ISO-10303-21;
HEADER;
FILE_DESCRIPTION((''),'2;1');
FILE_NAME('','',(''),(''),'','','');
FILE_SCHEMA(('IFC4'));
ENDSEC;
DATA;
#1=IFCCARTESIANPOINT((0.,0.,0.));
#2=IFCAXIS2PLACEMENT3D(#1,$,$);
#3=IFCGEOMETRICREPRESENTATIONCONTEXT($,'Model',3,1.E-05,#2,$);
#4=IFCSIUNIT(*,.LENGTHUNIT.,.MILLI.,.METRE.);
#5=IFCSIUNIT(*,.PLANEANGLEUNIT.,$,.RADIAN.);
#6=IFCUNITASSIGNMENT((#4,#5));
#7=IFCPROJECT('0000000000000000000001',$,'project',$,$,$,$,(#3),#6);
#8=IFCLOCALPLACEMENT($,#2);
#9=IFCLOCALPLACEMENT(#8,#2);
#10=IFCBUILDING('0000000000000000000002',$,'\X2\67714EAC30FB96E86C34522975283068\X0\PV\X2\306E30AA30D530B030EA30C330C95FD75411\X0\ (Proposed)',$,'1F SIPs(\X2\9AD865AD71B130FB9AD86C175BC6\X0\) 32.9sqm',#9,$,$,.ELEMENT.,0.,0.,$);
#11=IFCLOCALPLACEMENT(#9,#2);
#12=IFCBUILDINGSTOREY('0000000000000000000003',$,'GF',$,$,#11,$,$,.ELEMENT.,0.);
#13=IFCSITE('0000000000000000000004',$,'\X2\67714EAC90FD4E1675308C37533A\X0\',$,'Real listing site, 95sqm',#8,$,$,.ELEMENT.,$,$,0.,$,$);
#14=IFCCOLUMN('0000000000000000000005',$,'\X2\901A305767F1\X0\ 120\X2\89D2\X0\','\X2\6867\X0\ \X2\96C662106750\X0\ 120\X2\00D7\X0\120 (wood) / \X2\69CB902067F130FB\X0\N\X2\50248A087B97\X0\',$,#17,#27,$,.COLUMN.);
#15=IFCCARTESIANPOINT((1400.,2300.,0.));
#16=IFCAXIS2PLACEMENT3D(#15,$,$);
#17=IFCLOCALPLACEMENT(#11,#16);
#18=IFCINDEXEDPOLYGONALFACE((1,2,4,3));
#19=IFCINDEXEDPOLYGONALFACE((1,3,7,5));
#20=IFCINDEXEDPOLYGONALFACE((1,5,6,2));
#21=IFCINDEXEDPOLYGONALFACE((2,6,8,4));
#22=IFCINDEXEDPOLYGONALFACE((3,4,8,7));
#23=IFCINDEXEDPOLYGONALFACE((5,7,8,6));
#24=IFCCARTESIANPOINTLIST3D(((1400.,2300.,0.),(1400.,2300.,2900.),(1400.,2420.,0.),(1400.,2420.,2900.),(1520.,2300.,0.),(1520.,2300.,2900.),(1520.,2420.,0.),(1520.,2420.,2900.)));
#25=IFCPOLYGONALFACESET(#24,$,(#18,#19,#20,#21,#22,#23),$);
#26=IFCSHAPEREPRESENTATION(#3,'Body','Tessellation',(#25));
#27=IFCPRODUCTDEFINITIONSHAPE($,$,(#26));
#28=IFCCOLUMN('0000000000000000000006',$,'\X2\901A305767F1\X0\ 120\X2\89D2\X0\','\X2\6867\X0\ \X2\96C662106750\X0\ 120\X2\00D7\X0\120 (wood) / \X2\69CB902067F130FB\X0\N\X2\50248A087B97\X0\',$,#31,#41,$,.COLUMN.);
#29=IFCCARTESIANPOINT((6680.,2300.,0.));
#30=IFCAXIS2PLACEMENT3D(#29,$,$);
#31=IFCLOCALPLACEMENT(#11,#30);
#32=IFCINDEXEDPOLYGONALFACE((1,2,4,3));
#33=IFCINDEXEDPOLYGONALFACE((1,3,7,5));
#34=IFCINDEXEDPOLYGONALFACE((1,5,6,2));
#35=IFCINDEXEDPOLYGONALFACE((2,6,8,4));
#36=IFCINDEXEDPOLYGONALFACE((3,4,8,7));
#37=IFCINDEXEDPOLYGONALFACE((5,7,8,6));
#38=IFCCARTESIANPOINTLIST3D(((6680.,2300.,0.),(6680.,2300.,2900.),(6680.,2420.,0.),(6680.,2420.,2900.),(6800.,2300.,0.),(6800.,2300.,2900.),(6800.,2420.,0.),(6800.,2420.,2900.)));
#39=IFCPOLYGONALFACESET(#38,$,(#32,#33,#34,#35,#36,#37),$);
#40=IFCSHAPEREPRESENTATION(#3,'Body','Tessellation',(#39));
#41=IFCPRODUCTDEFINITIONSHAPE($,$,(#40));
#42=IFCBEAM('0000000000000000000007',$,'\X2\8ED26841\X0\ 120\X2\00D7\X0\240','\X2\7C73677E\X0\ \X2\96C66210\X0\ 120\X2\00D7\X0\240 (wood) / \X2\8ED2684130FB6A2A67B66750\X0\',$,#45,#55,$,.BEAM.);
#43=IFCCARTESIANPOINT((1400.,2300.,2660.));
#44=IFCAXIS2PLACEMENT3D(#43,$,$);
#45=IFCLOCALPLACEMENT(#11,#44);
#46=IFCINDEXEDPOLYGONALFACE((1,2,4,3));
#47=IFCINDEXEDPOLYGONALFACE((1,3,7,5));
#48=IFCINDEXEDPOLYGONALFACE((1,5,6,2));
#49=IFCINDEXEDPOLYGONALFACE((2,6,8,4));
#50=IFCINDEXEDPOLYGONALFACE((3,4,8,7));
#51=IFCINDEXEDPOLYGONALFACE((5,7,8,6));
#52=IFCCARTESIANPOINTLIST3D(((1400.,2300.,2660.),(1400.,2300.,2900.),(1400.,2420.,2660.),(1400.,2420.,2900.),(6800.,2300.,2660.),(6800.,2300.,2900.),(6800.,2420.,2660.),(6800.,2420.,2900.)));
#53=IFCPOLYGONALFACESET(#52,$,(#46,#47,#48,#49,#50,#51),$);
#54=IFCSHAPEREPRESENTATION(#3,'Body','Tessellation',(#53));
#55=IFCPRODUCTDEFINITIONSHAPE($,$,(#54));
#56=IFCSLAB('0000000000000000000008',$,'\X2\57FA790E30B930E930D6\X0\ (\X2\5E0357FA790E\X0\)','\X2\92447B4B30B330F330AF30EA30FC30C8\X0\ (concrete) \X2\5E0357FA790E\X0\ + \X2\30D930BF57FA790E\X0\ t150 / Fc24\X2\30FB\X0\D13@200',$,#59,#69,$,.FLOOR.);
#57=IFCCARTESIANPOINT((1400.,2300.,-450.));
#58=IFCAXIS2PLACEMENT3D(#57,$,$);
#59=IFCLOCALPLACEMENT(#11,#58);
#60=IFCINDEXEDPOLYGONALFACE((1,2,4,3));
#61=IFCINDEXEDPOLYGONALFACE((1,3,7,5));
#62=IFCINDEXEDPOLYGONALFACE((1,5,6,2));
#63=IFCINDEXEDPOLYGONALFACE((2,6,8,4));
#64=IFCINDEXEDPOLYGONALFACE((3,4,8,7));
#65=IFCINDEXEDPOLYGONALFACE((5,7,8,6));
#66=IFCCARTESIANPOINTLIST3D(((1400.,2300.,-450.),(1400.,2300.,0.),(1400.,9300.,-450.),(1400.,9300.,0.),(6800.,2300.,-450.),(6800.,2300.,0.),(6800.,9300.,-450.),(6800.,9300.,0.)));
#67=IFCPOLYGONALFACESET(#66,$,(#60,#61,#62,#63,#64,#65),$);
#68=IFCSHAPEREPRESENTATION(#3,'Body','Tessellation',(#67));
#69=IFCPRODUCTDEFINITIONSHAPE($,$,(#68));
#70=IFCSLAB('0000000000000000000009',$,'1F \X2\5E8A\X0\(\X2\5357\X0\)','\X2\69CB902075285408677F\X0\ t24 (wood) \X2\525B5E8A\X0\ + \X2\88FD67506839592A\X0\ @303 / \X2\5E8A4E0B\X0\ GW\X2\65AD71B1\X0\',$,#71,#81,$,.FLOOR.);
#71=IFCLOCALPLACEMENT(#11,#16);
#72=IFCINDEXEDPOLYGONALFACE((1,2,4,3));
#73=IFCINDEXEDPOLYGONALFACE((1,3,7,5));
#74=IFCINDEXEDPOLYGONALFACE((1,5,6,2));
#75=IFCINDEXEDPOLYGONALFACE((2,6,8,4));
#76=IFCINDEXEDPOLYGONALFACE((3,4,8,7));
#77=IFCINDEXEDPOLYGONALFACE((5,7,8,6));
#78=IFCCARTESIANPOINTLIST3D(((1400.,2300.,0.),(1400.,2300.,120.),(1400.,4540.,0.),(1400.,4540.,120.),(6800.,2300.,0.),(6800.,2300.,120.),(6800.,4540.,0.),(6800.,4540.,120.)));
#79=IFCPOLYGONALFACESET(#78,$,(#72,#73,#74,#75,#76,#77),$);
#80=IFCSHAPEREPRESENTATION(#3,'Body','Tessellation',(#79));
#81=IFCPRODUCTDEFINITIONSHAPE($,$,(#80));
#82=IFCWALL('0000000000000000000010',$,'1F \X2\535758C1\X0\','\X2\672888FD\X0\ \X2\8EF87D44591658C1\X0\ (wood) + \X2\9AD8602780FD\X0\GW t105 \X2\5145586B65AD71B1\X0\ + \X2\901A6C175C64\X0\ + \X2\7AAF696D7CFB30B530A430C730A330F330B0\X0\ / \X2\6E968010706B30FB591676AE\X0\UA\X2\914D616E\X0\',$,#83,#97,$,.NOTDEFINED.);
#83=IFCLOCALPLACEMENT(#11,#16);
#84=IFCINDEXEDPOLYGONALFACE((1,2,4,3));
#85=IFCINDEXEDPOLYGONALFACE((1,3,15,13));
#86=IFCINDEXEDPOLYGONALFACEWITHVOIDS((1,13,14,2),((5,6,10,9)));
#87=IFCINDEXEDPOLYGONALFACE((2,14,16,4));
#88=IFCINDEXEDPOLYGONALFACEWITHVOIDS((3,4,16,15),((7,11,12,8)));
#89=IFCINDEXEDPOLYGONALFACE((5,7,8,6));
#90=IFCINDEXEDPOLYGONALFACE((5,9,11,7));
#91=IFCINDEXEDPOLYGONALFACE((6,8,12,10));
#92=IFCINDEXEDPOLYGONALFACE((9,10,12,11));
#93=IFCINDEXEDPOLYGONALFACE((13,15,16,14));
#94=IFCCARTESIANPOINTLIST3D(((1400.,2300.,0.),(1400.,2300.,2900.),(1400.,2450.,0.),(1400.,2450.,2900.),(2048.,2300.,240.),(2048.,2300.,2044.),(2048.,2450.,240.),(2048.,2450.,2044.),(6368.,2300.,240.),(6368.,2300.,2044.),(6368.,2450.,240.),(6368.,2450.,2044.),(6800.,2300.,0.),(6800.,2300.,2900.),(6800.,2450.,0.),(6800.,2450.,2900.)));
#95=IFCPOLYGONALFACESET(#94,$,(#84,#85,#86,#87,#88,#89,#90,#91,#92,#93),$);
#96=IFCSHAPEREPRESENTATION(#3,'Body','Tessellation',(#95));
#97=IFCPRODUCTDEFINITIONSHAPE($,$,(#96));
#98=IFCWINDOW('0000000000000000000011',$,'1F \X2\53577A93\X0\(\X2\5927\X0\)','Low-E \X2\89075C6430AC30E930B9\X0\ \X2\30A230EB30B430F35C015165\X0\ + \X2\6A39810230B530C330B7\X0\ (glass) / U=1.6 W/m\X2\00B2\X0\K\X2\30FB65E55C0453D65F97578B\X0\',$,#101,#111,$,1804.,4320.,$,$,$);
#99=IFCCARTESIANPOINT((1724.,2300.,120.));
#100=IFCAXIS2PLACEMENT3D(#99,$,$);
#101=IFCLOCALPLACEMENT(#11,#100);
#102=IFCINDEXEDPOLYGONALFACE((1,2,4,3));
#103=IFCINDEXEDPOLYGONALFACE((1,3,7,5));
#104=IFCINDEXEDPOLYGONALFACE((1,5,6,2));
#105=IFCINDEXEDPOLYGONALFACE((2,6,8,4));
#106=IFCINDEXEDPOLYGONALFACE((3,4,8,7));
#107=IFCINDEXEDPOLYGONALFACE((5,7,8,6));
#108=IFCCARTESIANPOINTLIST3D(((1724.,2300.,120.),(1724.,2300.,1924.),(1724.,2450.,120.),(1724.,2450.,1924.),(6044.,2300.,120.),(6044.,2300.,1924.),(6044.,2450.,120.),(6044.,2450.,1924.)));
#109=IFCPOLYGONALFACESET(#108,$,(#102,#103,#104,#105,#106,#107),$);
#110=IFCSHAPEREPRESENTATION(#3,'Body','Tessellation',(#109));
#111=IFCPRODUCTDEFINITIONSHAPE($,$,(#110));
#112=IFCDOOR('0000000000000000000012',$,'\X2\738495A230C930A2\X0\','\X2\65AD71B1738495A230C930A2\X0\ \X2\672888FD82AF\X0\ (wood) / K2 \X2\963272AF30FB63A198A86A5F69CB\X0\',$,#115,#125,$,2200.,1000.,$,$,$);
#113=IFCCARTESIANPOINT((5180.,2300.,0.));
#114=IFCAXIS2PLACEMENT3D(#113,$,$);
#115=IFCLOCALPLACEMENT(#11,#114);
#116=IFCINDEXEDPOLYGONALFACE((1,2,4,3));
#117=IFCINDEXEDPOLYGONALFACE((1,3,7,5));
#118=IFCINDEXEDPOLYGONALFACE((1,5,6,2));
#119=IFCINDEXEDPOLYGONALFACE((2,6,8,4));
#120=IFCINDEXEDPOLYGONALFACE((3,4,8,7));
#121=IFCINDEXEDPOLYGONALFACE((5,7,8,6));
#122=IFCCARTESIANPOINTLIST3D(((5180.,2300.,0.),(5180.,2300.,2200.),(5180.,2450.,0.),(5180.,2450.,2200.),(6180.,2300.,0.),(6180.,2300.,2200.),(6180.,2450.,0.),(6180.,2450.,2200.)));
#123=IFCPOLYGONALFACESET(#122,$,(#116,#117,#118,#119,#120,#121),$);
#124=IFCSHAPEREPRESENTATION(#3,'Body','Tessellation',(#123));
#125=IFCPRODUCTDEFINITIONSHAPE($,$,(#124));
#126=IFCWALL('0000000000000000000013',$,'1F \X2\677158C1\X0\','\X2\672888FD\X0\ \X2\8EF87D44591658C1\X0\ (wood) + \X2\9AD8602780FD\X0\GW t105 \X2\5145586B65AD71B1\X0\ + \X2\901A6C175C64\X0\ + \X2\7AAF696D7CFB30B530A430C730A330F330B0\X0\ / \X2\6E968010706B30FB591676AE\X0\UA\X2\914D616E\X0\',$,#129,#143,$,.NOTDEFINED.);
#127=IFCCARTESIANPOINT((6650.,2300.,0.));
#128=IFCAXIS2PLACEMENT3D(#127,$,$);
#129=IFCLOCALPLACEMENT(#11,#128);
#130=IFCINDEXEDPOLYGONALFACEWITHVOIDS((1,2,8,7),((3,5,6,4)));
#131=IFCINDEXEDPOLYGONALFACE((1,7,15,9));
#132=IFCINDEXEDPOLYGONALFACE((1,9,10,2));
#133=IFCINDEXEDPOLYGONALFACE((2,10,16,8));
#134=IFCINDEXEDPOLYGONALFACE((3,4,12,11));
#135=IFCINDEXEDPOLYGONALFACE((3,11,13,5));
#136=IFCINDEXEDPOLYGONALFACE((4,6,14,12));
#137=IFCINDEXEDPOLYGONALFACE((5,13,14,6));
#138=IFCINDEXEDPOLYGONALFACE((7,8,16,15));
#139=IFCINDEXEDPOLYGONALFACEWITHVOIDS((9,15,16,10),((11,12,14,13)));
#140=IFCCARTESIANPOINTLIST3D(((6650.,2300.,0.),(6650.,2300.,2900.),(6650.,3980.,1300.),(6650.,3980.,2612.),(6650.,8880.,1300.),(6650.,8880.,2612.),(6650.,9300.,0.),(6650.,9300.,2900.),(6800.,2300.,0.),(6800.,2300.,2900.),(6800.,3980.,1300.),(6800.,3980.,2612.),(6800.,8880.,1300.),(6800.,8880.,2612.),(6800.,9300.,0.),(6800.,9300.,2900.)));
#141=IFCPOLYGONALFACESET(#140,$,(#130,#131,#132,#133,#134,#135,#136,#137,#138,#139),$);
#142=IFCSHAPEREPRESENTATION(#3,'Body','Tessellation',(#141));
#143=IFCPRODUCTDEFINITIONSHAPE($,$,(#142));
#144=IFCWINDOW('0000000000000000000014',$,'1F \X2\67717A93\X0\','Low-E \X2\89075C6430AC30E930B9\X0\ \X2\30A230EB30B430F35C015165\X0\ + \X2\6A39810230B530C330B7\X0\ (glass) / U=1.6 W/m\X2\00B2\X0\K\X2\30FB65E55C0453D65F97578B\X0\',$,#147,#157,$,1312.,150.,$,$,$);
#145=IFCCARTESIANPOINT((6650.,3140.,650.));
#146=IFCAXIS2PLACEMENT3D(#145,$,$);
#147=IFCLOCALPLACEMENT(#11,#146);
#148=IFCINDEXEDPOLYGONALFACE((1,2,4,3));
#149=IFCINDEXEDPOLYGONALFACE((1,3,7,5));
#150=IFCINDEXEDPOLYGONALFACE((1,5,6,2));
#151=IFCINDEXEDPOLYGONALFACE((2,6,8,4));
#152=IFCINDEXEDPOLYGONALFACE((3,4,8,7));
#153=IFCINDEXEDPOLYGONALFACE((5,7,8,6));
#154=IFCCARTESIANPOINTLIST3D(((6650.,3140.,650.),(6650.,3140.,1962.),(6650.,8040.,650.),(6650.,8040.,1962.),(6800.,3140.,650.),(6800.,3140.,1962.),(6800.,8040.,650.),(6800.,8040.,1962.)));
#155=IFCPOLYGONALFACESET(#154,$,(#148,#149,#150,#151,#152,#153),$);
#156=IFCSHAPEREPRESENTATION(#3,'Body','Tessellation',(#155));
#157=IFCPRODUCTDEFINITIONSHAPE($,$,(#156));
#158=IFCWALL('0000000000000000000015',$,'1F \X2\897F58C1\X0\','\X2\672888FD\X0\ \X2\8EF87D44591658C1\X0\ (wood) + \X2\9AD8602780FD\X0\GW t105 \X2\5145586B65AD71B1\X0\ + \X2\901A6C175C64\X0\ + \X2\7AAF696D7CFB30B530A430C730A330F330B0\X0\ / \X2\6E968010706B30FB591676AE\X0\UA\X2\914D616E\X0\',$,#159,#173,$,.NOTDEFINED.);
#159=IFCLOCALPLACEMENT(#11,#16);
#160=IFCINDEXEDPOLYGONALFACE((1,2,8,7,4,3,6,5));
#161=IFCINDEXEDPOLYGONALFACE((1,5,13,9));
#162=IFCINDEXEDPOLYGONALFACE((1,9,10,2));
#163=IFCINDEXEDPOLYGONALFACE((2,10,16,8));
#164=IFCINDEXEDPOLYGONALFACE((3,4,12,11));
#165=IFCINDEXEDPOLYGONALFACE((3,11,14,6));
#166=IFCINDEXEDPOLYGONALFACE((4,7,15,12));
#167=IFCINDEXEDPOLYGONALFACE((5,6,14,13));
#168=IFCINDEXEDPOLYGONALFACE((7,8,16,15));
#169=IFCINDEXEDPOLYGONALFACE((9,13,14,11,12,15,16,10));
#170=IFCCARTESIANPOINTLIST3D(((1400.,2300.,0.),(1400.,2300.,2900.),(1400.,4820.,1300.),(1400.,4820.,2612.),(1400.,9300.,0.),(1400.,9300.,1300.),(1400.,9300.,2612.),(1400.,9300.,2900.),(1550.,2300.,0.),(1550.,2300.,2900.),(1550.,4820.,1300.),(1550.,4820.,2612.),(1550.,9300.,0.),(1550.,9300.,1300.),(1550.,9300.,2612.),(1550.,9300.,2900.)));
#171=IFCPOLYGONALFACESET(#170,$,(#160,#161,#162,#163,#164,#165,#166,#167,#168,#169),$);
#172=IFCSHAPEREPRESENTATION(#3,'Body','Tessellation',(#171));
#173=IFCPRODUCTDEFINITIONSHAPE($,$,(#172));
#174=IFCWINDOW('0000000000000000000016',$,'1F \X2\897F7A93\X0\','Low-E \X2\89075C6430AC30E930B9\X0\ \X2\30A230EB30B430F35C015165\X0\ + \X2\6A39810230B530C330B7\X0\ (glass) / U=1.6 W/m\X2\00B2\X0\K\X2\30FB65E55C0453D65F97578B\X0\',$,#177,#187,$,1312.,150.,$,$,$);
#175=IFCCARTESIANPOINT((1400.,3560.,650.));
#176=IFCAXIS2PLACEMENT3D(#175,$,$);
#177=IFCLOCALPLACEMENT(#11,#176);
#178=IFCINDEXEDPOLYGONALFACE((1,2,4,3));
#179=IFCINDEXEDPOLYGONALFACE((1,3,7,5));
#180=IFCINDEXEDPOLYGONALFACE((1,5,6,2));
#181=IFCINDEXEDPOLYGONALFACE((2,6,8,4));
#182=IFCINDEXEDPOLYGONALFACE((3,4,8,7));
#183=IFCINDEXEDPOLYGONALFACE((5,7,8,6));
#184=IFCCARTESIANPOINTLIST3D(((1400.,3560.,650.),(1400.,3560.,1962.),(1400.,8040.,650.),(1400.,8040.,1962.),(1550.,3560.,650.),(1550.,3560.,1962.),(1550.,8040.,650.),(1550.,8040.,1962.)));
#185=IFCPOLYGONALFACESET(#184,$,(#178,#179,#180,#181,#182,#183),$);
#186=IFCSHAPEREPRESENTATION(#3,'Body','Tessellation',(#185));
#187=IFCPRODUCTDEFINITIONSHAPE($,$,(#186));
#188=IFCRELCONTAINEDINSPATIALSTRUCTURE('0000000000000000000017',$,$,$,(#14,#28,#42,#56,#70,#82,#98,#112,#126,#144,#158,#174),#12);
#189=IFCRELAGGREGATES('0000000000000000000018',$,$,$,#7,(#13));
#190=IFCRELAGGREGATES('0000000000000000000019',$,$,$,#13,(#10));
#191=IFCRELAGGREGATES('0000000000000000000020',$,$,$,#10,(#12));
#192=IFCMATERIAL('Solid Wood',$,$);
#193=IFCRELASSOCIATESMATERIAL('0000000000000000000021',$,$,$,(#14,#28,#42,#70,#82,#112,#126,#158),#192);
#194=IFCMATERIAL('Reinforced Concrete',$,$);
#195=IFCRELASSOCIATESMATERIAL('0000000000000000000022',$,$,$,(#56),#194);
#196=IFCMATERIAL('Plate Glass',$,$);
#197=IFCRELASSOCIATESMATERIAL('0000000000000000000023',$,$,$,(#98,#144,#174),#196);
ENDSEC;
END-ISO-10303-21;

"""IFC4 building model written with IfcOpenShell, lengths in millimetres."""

from ifc_helpers import new_model, si_unit, frame, frame_2d, origin, place, context, project, spatial, rectangle, extrude, material, element, fill, save


model = new_model("IFC4")

# Units and contexts
model_context = context("Model", 3, precision=1e-05, world=origin())
ifc_project = project(units=[si_unit("LENGTHUNIT", "METRE", prefix="MILLI"), si_unit("PLANEANGLEUNIT", "RADIAN")], contexts=[model_context])

# Site, building, storey
site_placement = place(None, origin())
site = spatial("IfcSite", under=ifc_project, at=site_placement, Name="東京都世田谷区", ObjectType="Real listing site, 95sqm", CompositionType="ELEMENT", RefElevation=0.0)
building_placement = place(site_placement, origin())
building = spatial("IfcBuilding", under=site, at=building_placement, Name="東京・雨水利用とPVのオフグリッド志向 (Proposed)", ObjectType="1F SIPs(高断熱・高気密) 32.9sqm", CompositionType="ELEMENT", ElevationOfRefHeight=0.0, ElevationOfTerrain=0.0)
storey_placement = place(building_placement, origin())
storey = spatial("IfcBuildingStorey", under=building, at=storey_placement, Name="GF", CompositionType="ELEMENT", Elevation=0.0)

# Columns
ifc_material_1 = material(Name="Solid Wood")
column_1_placement = place(storey_placement, frame((1400.0, 2300.0, 0.0)))
element("IfcColumn", 1, at=column_1_placement, inside=storey, material=ifc_material_1, Name="通し柱 120角", Description="桧 集成材 120×120 (wood) / 構造柱・N値計算", PredefinedType="COLUMN", context=model_context, shape_type="SweptSolid", body=[
    extrude(rectangle(XDim=120.0, YDim=120.0, at=frame_2d((60.0, 60.0))), frame((1400.0, 2300.0, 0.0)), (0.0, 0.0, 1.0), 2900.0),
])
column_2_placement = place(storey_placement, frame((6680.0, 2300.0, 0.0)))
element("IfcColumn", 2, at=column_2_placement, inside=storey, material=ifc_material_1, Name="通し柱 120角", Description="桧 集成材 120×120 (wood) / 構造柱・N値計算", PredefinedType="COLUMN", context=model_context, shape_type="SweptSolid", body=[
    extrude(rectangle(XDim=120.0, YDim=120.0, at=frame_2d((60.0, 60.0))), frame((6680.0, 2300.0, 0.0)), (0.0, 0.0, 1.0), 2900.0),
])

# Beam
beam_1_placement = place(storey_placement, frame((1400.0, 2300.0, 2660.0)))
element("IfcBeam", 3, at=beam_1_placement, inside=storey, material=ifc_material_1, Name="軒桁 120×240", Description="米松 集成 120×240 (wood) / 軒桁・横架材", PredefinedType="BEAM", context=model_context, shape_type="SweptSolid", body=[
    extrude(rectangle(XDim=5400.0, YDim=120.0, at=frame_2d((2700.0, 60.0))), frame((1400.0, 2300.0, 2660.0)), (0.0, 0.0, 1.0), 240.0),
])

# Slabs
ifc_material_2 = material(Name="Reinforced Concrete")
slab_1_placement = place(storey_placement, frame((1400.0, 2300.0, -450.0)))
element("IfcSlab", 4, at=slab_1_placement, inside=storey, material=ifc_material_2, Name="基礎スラブ (布基礎)", Description="鉄筋コンクリート (concrete) 布基礎 + ベタ基礎 t150 / Fc24・D13@200", PredefinedType="FLOOR", context=model_context, shape_type="SweptSolid", body=[
    extrude(rectangle(XDim=5400.0, YDim=7000.0, at=frame_2d((2700.0, 3500.0))), frame((1400.0, 2300.0, -450.0)), (0.0, 0.0, 1.0), 450.0),
])
slab_2_placement = place(storey_placement, frame((1400.0, 2300.0, 0.0)))
element("IfcSlab", 5, at=slab_2_placement, inside=storey, material=ifc_material_1, Name="1F 床(南)", Description="構造用合板 t24 (wood) 剛床 + 製材根太 @303 / 床下 GW断熱", PredefinedType="FLOOR", context=model_context, shape_type="SweptSolid", body=[
    extrude(rectangle(XDim=5400.0, YDim=2240.0, at=frame_2d((2700.0, 1120.0))), frame((1400.0, 2300.0, 0.0)), (0.0, 0.0, 1.0), 120.0),
])

# Wall, openings, window, door
wall_1_placement = place(storey_placement, frame((1400.0, 2300.0, 0.0)))
wall_1 = element("IfcWall", 6, at=wall_1_placement, inside=storey, material=ifc_material_1, Name="1F 南壁", Description="木製 軸組外壁 (wood) + 高性能GW t105 充填断熱 + 通気層 + 窯業系サイディング / 準耐火・外皮UA配慮", PredefinedType="NOTDEFINED", context=model_context, shape_type="SweptSolid", body=[
    extrude(rectangle(XDim=5400.0, YDim=150.0, at=frame_2d((2700.0, 75.0))), frame((1400.0, 2300.0, 0.0)), (0.0, 0.0, 1.0), 2900.0),
])
opening_1_placement = place(storey_placement, frame((1724.0, 2300.0, 120.0)))
opening_1 = element("IfcOpeningElement", 7, at=opening_1_placement, cuts=wall_1, PredefinedType="NOTDEFINED", context=model_context, shape_type="SweptSolid", body=[
    extrude(rectangle(XDim=4320.0, YDim=150.0, at=frame_2d((2160.0, 75.0))), frame((1724.0, 2300.0, 120.0)), (0.0, 0.0, 1.0), 1804.0),
])
opening_2_placement = place(storey_placement, frame((5180.0, 2300.0, 0.0)))
opening_2 = element("IfcOpeningElement", 8, at=opening_2_placement, cuts=wall_1, PredefinedType="NOTDEFINED", context=model_context, shape_type="SweptSolid", body=[
    extrude(rectangle(XDim=1000.0, YDim=150.0, at=frame_2d((500.0, 75.0))), frame((5180.0, 2300.0, 0.0)), (0.0, 0.0, 1.0), 2200.0),
])
ifc_material_3 = material(Name="Plate Glass")
window_1_placement = place(storey_placement, frame((1724.0, 2300.0, 120.0)))
window_1 = element("IfcWindow", 9, at=window_1_placement, inside=storey, material=ifc_material_3, Name="1F 南窓(大)", Description="Low-E 複層ガラス アルゴン封入 + 樹脂サッシ (glass) / U=1.6 W/m²K・日射取得型", OverallHeight=1804.0, OverallWidth=4320.0, context=model_context, shape_type="SweptSolid", body=[
    extrude(rectangle(XDim=4320.0, YDim=150.0, at=frame_2d((2160.0, 75.0))), frame((1724.0, 2300.0, 120.0)), (0.0, 0.0, 1.0), 1804.0),
])
fill(opening_1, window_1)
door_placement = place(storey_placement, frame((5180.0, 2300.0, 0.0)))
door = element("IfcDoor", 10, at=door_placement, inside=storey, material=ifc_material_1, Name="玄関ドア", Description="断熱玄関ドア 木製芯 (wood) / K2 防犯・採風機構", OverallHeight=2200.0, OverallWidth=1000.0, context=model_context, shape_type="SweptSolid", body=[
    extrude(rectangle(XDim=1000.0, YDim=150.0, at=frame_2d((500.0, 75.0))), frame((5180.0, 2300.0, 0.0)), (0.0, 0.0, 1.0), 2200.0),
])
fill(opening_2, door)

# Walls, openings, windows
wall_2_placement = place(storey_placement, frame((6650.0, 2300.0, 0.0)))
wall_2 = element("IfcWall", 11, at=wall_2_placement, inside=storey, material=ifc_material_1, Name="1F 東壁", Description="木製 軸組外壁 (wood) + 高性能GW t105 充填断熱 + 通気層 + 窯業系サイディング / 準耐火・外皮UA配慮", PredefinedType="NOTDEFINED", context=model_context, shape_type="SweptSolid", body=[
    extrude(rectangle(XDim=150.0, YDim=7000.0, at=frame_2d((75.0, 3500.0))), frame((6650.0, 2300.0, 0.0)), (0.0, 0.0, 1.0), 2900.0),
])
opening_3_placement = place(storey_placement, frame((6650.0, 3140.0, 650.0)))
opening_3 = element("IfcOpeningElement", 12, at=opening_3_placement, cuts=wall_2, PredefinedType="NOTDEFINED", context=model_context, shape_type="SweptSolid", body=[
    extrude(rectangle(XDim=150.0, YDim=4900.0, at=frame_2d((75.0, 2450.0))), frame((6650.0, 3140.0, 650.0)), (0.0, 0.0, 1.0), 1312.0),
])
window_2_placement = place(storey_placement, frame((6650.0, 3140.0, 650.0)))
window_2 = element("IfcWindow", 13, at=window_2_placement, inside=storey, material=ifc_material_3, Name="1F 東窓", Description="Low-E 複層ガラス アルゴン封入 + 樹脂サッシ (glass) / U=1.6 W/m²K・日射取得型", OverallHeight=1312.0, OverallWidth=150.0, context=model_context, shape_type="SweptSolid", body=[
    extrude(rectangle(XDim=150.0, YDim=4900.0, at=frame_2d((75.0, 2450.0))), frame((6650.0, 3140.0, 650.0)), (0.0, 0.0, 1.0), 1312.0),
])
fill(opening_3, window_2)
wall_3_placement = place(storey_placement, frame((1400.0, 2300.0, 0.0)))
wall_3 = element("IfcWall", 14, at=wall_3_placement, inside=storey, material=ifc_material_1, Name="1F 西壁", Description="木製 軸組外壁 (wood) + 高性能GW t105 充填断熱 + 通気層 + 窯業系サイディング / 準耐火・外皮UA配慮", PredefinedType="NOTDEFINED", context=model_context, shape_type="SweptSolid", body=[
    extrude(rectangle(XDim=150.0, YDim=7000.0, at=frame_2d((75.0, 3500.0))), frame((1400.0, 2300.0, 0.0)), (0.0, 0.0, 1.0), 2900.0),
])
opening_4_placement = place(storey_placement, frame((1400.0, 3560.0, 650.0)))
opening_4 = element("IfcOpeningElement", 15, at=opening_4_placement, cuts=wall_3, PredefinedType="NOTDEFINED", context=model_context, shape_type="SweptSolid", body=[
    extrude(rectangle(XDim=150.0, YDim=4480.0, at=frame_2d((75.0, 2240.0))), frame((1400.0, 3560.0, 650.0)), (0.0, 0.0, 1.0), 1312.0),
])
window_3_placement = place(storey_placement, frame((1400.0, 3560.0, 650.0)))
window_3 = element("IfcWindow", 16, at=window_3_placement, inside=storey, material=ifc_material_3, Name="1F 西窓", Description="Low-E 複層ガラス アルゴン封入 + 樹脂サッシ (glass) / U=1.6 W/m²K・日射取得型", OverallHeight=1312.0, OverallWidth=150.0, context=model_context, shape_type="SweptSolid", body=[
    extrude(rectangle(XDim=150.0, YDim=4480.0, at=frame_2d((75.0, 2240.0))), frame((1400.0, 3560.0, 650.0)), (0.0, 0.0, 1.0), 1312.0),
])
fill(opening_4, window_3)

save(model, "model.ifc")
